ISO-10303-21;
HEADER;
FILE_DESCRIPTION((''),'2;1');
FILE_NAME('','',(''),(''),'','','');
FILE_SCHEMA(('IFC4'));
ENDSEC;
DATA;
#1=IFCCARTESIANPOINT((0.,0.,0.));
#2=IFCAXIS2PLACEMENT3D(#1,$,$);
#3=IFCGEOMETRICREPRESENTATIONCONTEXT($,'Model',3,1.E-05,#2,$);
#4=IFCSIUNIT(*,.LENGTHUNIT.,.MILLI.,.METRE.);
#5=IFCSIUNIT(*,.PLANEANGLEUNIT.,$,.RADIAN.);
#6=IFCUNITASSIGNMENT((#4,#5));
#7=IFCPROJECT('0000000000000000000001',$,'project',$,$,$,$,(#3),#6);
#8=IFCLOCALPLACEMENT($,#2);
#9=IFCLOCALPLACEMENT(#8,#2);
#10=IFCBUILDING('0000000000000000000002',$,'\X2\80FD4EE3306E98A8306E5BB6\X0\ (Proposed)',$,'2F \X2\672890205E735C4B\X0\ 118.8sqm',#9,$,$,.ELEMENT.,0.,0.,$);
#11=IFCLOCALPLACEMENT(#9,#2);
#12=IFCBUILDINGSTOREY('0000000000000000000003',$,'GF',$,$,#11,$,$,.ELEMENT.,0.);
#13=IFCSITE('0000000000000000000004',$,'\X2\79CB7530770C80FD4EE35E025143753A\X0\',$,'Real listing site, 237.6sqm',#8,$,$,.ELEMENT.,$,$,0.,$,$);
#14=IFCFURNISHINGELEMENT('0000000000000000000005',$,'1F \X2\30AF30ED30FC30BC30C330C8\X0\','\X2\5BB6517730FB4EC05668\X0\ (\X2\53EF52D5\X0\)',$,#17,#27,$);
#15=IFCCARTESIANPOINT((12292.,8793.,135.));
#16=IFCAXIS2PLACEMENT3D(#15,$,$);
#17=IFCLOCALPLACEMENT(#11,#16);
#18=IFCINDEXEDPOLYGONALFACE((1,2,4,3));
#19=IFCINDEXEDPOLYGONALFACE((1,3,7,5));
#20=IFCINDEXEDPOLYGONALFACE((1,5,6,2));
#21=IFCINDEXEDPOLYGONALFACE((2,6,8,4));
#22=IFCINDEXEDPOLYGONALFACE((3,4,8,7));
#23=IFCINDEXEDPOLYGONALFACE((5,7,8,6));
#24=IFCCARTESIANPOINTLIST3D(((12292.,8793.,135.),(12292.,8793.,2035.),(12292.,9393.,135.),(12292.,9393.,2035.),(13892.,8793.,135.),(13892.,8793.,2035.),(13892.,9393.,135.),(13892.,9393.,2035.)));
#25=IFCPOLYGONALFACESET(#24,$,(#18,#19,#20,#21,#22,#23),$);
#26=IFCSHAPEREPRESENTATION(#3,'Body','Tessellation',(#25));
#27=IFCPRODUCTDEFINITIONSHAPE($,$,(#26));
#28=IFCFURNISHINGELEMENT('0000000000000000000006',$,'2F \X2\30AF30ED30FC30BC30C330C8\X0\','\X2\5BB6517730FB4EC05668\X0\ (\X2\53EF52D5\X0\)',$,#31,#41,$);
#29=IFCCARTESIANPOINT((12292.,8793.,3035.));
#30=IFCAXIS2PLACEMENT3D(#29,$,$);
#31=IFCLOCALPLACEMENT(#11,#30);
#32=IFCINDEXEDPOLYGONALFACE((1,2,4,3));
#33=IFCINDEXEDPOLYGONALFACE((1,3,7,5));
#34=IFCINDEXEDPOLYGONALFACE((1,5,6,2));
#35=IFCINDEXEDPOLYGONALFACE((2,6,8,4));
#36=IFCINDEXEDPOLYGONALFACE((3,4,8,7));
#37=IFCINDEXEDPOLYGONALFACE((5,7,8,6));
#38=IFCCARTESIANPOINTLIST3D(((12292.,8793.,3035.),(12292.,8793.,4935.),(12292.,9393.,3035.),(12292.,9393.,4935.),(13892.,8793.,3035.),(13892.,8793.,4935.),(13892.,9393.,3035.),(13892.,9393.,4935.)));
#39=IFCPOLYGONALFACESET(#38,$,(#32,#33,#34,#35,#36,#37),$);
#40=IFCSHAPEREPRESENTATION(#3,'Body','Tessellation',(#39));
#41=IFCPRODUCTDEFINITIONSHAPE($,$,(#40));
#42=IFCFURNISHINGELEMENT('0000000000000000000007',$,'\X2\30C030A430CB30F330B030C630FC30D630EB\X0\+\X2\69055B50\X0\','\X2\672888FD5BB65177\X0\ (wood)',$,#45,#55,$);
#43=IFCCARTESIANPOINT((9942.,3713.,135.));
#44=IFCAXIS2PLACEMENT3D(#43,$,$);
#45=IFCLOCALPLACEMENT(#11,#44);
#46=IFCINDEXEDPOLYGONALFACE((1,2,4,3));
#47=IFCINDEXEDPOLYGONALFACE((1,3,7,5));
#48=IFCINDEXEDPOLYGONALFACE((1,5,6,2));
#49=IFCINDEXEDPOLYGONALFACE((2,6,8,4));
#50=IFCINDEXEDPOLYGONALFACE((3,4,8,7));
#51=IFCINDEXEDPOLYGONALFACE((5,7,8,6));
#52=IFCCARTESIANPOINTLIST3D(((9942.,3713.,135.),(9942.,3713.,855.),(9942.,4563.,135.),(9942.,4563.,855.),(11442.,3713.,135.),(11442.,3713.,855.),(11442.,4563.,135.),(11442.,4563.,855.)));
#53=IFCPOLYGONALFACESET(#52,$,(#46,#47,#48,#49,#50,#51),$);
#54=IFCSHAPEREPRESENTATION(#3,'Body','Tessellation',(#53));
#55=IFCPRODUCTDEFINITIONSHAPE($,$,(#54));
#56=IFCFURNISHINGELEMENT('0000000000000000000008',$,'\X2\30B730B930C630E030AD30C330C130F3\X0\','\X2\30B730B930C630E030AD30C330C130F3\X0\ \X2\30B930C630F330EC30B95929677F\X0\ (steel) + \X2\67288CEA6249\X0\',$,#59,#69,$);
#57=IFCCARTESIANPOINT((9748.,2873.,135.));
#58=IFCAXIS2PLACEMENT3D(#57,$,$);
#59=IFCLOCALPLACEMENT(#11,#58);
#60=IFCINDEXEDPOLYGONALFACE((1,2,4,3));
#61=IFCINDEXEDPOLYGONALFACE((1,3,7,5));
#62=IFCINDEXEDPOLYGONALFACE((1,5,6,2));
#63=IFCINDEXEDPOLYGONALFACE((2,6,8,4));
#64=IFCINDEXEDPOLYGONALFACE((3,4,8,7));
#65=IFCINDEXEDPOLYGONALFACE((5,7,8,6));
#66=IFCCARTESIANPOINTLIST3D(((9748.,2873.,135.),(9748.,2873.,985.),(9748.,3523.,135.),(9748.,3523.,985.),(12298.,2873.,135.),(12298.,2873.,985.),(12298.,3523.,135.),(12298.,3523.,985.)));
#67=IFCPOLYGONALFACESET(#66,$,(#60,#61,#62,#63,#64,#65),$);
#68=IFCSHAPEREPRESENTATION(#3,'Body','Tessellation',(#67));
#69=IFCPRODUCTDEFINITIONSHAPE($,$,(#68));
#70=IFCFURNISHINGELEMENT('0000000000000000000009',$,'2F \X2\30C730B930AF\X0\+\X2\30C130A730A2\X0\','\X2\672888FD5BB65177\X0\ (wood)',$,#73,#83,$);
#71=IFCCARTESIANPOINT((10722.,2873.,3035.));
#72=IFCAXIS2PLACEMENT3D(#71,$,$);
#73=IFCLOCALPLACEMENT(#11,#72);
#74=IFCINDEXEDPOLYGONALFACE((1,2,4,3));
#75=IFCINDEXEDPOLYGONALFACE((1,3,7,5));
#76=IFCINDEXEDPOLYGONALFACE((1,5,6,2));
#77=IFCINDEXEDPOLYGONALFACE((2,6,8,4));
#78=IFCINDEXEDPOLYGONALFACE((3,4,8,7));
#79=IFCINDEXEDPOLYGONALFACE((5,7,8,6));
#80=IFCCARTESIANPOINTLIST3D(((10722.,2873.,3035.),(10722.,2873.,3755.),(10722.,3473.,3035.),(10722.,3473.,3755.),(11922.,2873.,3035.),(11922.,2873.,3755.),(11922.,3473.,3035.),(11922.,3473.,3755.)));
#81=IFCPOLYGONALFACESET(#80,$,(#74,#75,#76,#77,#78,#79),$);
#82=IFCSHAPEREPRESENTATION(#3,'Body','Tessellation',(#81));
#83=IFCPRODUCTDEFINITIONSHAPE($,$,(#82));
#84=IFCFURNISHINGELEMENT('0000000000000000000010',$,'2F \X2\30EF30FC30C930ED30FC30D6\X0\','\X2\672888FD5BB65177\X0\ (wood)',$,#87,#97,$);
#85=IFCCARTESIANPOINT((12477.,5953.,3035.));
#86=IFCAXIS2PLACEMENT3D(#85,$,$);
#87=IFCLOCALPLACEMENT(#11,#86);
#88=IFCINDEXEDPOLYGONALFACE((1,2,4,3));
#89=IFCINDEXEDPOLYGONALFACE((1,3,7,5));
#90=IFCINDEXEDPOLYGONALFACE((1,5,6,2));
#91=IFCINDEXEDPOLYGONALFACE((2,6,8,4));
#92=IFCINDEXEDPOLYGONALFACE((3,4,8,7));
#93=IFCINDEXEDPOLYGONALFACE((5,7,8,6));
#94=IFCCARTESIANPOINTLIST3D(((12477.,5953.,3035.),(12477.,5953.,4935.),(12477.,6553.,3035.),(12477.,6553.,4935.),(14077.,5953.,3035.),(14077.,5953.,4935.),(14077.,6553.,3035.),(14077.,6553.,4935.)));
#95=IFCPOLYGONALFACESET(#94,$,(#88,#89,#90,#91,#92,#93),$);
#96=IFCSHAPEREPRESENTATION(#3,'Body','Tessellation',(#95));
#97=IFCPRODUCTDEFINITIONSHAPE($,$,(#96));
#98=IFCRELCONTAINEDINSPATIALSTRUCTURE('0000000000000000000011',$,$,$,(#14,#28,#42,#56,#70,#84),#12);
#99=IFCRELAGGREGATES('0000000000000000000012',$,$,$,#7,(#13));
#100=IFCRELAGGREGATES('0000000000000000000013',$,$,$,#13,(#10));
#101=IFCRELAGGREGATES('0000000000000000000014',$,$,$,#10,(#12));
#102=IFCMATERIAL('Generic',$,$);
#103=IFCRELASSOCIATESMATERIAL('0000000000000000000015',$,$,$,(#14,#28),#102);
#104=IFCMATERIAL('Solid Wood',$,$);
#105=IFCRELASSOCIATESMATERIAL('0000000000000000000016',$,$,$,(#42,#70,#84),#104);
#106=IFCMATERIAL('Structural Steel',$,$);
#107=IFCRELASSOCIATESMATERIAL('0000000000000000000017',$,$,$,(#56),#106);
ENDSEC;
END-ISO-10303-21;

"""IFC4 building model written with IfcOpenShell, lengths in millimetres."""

from ifc_helpers import new_model, si_unit, frame, frame_2d, origin, place, context, project, spatial, rectangle, extrude, material, element, save


model = new_model("IFC4")

# Units and contexts
model_context = context("Model", 3, precision=1e-05, world=origin())
ifc_project = project(units=[si_unit("LENGTHUNIT", "METRE", prefix="MILLI"), si_unit("PLANEANGLEUNIT", "RADIAN")], contexts=[model_context])

# Site, building, storey
site_placement = place(None, origin())
site = spatial("IfcSite", under=ifc_project, at=site_placement, Name="秋田県能代市元町", ObjectType="Real listing site, 237.6sqm", CompositionType="ELEMENT", RefElevation=0.0)
building_placement = place(site_placement, origin())
building = spatial("IfcBuilding", under=site, at=building_placement, Name="能代の風の家 (Proposed)", ObjectType="2F 木造平屋 118.8sqm", CompositionType="ELEMENT", ElevationOfRefHeight=0.0, ElevationOfTerrain=0.0)
storey_placement = place(building_placement, origin())
storey = spatial("IfcBuildingStorey", under=building, at=storey_placement, Name="GF", CompositionType="ELEMENT", Elevation=0.0)

# Shared definitions
ifc_material_1 = material(Name="Solid Wood")

# Shared definitions
ifc_material_2 = material(Name="Generic")

# Furnishing elements
furnishing_1_placement = place(storey_placement, frame((12292.0, 8793.0, 135.0)))
element("IfcFurnishingElement", 1, at=furnishing_1_placement, inside=storey, material=ifc_material_2, Name="1F クローゼット", Description="家具・什器 (可動)", context=model_context, shape_type="SweptSolid", body=[
    extrude(rectangle(XDim=1600.0, YDim=600.0, at=frame_2d((800.0, 300.0))), frame((12292.0, 8793.0, 135.0)), (0.0, 0.0, 1.0), 1900.0),
])
furnishing_2_placement = place(storey_placement, frame((12292.0, 8793.0, 3035.0)))
element("IfcFurnishingElement", 2, at=furnishing_2_placement, inside=storey, material=ifc_material_2, Name="2F クローゼット", Description="家具・什器 (可動)", context=model_context, shape_type="SweptSolid", body=[
    extrude(rectangle(XDim=1600.0, YDim=600.0, at=frame_2d((800.0, 300.0))), frame((12292.0, 8793.0, 3035.0)), (0.0, 0.0, 1.0), 1900.0),
])
furnishing_3_placement = place(storey_placement, frame((9942.0, 3713.0, 135.0)))
element("IfcFurnishingElement", 3, at=furnishing_3_placement, inside=storey, material=ifc_material_1, Name="ダイニングテーブル+椅子", Description="木製家具 (wood)", context=model_context, shape_type="SweptSolid", body=[
    extrude(rectangle(XDim=1500.0, YDim=850.0, at=frame_2d((750.0, 425.0))), frame((9942.0, 3713.0, 135.0)), (0.0, 0.0, 1.0), 720.0),
])
ifc_material_3 = material(Name="Structural Steel")
furnishing_4_placement = place(storey_placement, frame((9748.0, 2873.0, 135.0)))
element("IfcFurnishingElement", 4, at=furnishing_4_placement, inside=storey, material=ifc_material_3, Name="システムキッチン", Description="システムキッチン ステンレス天板 (steel) + 木質扉", context=model_context, shape_type="SweptSolid", body=[
    extrude(rectangle(XDim=2550.0, YDim=650.0, at=frame_2d((1275.0, 325.0))), frame((9748.0, 2873.0, 135.0)), (0.0, 0.0, 1.0), 850.0),
])
furnishing_5_placement = place(storey_placement, frame((10722.0, 2873.0, 3035.0)))
element("IfcFurnishingElement", 5, at=furnishing_5_placement, inside=storey, material=ifc_material_1, Name="2F デスク+チェア", Description="木製家具 (wood)", context=model_context, shape_type="SweptSolid", body=[
    extrude(rectangle(XDim=1200.0, YDim=600.0, at=frame_2d((600.0, 300.0))), frame((10722.0, 2873.0, 3035.0)), (0.0, 0.0, 1.0), 720.0),
])
furnishing_6_placement = place(storey_placement, frame((12477.0, 5953.0, 3035.0)))
element("IfcFurnishingElement", 6, at=furnishing_6_placement, inside=storey, material=ifc_material_1, Name="2F ワードローブ", Description="木製家具 (wood)", context=model_context, shape_type="SweptSolid", body=[
    extrude(rectangle(XDim=1600.0, YDim=600.0, at=frame_2d((800.0, 300.0))), frame((12477.0, 5953.0, 3035.0)), (0.0, 0.0, 1.0), 1900.0),
])

save(model, "model.ifc")
